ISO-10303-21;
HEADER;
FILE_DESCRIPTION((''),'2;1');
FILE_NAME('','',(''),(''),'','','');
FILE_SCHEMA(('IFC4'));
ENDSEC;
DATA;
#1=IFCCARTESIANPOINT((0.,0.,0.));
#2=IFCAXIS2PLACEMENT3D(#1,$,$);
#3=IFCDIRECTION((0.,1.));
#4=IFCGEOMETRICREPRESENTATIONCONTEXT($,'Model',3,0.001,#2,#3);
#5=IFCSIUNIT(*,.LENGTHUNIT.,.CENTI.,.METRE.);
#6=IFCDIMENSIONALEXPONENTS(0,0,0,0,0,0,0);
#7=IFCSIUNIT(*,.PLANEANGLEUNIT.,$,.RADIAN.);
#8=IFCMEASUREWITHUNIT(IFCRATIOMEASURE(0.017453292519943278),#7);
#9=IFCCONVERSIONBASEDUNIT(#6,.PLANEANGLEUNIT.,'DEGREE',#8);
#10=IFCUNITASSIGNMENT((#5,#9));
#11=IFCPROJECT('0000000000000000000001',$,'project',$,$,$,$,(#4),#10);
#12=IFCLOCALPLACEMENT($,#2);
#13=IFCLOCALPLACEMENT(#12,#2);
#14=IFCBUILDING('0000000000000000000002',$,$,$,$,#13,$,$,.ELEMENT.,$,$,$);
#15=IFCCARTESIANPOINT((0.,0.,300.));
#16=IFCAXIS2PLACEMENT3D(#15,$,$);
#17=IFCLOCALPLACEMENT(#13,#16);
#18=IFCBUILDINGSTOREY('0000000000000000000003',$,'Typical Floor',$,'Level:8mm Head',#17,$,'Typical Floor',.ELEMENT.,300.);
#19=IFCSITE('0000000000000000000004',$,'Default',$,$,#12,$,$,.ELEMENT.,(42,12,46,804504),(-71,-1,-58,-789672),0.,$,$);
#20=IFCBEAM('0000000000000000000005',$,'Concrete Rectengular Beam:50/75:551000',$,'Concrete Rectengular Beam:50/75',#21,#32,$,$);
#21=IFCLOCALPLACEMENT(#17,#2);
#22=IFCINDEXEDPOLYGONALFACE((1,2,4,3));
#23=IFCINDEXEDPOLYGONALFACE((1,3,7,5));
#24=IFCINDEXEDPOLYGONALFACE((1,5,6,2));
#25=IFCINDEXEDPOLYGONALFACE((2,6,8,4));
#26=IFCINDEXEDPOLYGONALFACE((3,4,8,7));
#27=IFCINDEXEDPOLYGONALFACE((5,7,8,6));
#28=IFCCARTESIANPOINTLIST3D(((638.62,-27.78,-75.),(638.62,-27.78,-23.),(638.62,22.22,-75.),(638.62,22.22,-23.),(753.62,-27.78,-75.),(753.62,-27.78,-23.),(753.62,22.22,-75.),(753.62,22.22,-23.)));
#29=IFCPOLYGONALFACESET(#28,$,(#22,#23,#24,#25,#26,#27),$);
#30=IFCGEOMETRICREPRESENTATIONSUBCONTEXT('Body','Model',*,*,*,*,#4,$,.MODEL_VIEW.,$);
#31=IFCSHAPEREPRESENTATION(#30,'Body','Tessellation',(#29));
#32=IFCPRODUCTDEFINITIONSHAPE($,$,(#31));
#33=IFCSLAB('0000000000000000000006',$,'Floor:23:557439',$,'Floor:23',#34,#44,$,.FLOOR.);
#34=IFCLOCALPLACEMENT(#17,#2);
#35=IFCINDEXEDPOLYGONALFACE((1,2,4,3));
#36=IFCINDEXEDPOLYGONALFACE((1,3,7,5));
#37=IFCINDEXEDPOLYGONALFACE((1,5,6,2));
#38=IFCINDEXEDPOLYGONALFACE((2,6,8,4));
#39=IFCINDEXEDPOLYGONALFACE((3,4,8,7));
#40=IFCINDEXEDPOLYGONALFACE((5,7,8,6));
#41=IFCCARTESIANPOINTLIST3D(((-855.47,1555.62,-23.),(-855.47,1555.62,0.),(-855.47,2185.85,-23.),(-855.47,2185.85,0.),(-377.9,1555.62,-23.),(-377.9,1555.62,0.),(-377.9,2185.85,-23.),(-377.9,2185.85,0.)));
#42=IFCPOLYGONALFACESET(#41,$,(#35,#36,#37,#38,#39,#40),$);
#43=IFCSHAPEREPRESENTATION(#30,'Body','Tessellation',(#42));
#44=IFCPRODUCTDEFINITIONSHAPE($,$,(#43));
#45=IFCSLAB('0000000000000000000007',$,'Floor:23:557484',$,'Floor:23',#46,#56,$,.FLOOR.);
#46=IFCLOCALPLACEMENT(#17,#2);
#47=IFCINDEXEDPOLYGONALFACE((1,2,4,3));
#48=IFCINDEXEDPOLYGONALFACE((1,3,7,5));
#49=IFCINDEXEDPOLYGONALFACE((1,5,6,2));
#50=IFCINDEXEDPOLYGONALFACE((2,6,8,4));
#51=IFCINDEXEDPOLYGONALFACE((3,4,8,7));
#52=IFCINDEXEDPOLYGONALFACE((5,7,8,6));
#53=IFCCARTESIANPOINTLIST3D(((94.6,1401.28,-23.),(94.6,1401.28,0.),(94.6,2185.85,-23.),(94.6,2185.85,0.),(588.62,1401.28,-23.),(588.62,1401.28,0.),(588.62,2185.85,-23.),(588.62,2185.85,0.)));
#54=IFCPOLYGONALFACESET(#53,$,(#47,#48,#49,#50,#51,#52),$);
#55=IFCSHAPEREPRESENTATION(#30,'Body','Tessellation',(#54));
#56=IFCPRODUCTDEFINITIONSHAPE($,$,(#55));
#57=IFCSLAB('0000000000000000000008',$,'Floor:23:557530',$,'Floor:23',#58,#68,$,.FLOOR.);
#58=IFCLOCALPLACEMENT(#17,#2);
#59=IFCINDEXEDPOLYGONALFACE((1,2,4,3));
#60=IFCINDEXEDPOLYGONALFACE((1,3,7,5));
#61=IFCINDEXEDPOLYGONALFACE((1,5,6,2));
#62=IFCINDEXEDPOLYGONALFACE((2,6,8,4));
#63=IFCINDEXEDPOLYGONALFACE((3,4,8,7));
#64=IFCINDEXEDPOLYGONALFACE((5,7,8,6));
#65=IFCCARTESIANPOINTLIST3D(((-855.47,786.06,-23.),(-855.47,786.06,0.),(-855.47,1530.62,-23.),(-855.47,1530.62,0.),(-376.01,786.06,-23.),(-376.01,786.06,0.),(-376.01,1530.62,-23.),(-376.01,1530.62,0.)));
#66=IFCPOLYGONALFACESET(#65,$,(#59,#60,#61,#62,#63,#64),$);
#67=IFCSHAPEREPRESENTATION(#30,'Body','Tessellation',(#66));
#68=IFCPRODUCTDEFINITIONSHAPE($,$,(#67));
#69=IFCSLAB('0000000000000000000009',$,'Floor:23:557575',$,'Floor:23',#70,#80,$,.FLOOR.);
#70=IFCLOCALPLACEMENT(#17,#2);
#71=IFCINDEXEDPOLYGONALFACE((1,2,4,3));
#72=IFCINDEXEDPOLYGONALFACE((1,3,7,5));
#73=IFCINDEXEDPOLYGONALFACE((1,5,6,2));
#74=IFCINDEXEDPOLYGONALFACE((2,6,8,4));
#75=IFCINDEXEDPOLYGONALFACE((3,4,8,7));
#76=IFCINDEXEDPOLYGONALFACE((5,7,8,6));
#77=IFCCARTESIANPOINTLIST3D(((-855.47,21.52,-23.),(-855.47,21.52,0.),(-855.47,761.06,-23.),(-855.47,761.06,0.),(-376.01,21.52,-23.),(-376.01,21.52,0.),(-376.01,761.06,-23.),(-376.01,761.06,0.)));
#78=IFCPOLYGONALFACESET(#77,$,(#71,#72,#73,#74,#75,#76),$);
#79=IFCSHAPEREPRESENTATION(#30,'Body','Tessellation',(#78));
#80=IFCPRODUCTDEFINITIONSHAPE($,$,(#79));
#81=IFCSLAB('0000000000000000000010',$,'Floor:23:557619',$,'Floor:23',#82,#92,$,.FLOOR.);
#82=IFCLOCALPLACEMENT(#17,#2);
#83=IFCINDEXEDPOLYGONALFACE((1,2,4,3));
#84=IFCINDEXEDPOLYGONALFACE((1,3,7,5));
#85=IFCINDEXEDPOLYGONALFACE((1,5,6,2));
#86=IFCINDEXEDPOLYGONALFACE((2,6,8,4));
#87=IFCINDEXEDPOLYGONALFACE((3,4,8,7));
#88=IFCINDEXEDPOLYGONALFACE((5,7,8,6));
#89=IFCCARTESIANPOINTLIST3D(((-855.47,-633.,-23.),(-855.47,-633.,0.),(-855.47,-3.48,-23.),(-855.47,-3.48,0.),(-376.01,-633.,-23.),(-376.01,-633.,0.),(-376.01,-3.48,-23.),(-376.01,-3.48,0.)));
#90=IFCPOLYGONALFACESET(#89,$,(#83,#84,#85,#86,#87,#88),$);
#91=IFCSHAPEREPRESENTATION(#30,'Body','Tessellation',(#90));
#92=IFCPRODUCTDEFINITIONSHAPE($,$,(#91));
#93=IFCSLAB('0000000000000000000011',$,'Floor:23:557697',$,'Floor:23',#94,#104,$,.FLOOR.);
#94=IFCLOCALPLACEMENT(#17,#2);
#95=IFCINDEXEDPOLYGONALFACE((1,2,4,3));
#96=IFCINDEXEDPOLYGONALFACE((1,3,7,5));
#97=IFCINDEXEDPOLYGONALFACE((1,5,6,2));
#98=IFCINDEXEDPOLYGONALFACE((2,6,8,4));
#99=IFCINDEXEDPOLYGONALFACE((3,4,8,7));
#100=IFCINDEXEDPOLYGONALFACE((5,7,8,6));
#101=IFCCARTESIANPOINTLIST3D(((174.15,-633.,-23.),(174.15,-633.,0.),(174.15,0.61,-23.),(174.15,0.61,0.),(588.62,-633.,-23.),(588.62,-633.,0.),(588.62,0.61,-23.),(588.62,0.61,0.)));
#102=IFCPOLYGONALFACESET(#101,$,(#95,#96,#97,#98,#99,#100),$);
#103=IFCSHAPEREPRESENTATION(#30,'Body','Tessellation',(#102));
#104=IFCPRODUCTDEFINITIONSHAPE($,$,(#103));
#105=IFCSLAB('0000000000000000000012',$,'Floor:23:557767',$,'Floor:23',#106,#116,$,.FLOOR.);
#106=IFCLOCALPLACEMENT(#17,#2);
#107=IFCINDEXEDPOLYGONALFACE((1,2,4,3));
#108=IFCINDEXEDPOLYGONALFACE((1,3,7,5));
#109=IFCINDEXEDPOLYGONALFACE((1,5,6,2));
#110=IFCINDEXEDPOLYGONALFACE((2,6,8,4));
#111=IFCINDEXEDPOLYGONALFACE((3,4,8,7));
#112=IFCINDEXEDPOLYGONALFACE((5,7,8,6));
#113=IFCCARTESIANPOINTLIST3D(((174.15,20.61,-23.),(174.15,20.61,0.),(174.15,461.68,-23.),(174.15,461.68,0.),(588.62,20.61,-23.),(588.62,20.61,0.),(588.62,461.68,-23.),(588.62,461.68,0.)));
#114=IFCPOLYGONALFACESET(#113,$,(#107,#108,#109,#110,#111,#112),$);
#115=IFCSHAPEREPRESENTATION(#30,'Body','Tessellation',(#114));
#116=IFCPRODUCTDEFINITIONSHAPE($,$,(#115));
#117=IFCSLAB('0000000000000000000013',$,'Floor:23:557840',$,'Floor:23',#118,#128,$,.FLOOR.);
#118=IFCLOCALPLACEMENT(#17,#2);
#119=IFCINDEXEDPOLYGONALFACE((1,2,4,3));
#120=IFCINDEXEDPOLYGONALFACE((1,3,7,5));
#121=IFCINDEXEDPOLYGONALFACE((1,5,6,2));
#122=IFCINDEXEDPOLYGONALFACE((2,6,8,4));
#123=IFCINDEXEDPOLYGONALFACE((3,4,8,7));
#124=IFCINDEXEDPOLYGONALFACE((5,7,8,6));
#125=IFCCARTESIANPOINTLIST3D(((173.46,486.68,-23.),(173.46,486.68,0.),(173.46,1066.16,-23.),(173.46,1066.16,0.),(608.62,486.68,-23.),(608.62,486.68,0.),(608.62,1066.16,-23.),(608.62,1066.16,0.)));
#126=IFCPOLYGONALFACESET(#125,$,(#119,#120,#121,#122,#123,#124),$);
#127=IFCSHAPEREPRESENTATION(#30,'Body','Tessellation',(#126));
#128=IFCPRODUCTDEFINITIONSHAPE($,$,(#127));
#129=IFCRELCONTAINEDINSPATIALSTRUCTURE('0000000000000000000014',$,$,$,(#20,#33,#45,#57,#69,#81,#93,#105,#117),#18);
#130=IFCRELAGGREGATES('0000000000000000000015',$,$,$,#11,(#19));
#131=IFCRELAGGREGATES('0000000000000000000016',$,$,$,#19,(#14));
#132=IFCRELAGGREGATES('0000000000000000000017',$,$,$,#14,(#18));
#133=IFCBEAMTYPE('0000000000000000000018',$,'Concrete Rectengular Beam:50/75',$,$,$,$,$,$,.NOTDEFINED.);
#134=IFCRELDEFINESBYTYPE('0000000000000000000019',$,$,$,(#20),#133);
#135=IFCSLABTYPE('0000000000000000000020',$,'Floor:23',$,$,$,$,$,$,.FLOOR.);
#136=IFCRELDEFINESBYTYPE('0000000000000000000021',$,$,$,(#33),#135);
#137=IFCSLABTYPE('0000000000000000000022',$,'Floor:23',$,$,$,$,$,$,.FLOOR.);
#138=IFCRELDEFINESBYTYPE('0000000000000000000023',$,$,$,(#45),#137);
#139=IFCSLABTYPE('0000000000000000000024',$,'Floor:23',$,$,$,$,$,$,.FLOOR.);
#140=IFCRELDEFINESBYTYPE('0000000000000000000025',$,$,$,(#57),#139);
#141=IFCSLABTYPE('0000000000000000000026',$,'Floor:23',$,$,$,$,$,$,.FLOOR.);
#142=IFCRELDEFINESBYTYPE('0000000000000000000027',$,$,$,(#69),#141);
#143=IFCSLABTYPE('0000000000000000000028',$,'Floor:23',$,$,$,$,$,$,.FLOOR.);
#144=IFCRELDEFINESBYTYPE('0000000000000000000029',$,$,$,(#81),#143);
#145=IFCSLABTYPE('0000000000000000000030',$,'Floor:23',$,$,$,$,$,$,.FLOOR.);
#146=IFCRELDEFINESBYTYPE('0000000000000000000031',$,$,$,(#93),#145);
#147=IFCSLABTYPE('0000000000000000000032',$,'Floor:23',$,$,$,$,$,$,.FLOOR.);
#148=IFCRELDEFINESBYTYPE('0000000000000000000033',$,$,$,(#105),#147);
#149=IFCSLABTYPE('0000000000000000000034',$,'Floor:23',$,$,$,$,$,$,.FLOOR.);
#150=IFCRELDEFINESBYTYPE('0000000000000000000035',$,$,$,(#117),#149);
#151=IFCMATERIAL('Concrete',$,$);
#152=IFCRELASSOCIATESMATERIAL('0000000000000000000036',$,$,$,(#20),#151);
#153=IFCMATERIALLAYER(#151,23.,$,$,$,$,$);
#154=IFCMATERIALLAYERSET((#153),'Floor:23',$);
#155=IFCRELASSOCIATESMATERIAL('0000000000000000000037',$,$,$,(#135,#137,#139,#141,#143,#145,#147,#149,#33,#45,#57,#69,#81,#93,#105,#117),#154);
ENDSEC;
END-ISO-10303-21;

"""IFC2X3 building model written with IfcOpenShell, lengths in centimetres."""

from ifc_helpers import new_model, entity, si_unit, converted_unit, direction, frame, frame_2d, origin, origin_2d_with_axis, place, context, subcontext, project, spatial, rectangle, extrude, material, layer, layer_set, layer_usage, type_object, element, save


model = new_model("IFC2X3")

# Units and contexts
model_context = context("Model", 3, precision=0.001, world=origin(), true_north=direction((0.0, 1.0)))
body_context = subcontext(model_context, "Body", "Model", "MODEL_VIEW")
ifc_project = project(units=[si_unit("LENGTHUNIT", "METRE", prefix="CENTI"), converted_unit("PLANEANGLEUNIT", "DEGREE", entity("IfcRatioMeasure", 0.017453292519943278), si_unit("PLANEANGLEUNIT", "RADIAN"), dimensions=[0, 0, 0, 0, 0, 0, 0])], contexts=[model_context])

# Site, building, storey
site_placement = place(None, origin())
site = spatial("IfcSite", under=ifc_project, at=site_placement, Name="Default", CompositionType="ELEMENT", RefLatitude=(42, 12, 46, 804504), RefLongitude=(-71, -1, -58, -789672), RefElevation=0.0)
building_placement = place(site_placement, origin())
building = spatial("IfcBuilding", under=site, at=building_placement, CompositionType="ELEMENT")
storey_placement = place(building_placement, frame((0.0, 0.0, 300.0)))
storey = spatial("IfcBuildingStorey", under=building, at=storey_placement, Name="Typical Floor", ObjectType="Level:8mm Head", LongName="Typical Floor", CompositionType="ELEMENT", Elevation=300.0)

# Beam
ifc_material = material(Name="Concrete")
beam_type_1 = type_object("IfcBeamType", Name="Concrete Rectengular Beam:50/75", PredefinedType="NOTDEFINED")
beam_1_placement = place(storey_placement, frame((613.62, -2.78, 0.0)))
element("IfcBeam", 1, at=beam_1_placement, inside=storey, type_object=beam_type_1, material=ifc_material, Name="Concrete Rectengular Beam:50/75:551000", ObjectType="Concrete Rectengular Beam:50/75", context=body_context, shape_type="SweptSolid", body=[
    extrude(rectangle(XDim=52.0, YDim=50.0, at=frame_2d((0.0, 0.0), x_axis=(1.0, 0.0))), frame((25.0, 0.0, -49.0), z_axis=(1.0, 0.0, 0.0), x_axis=(0.0, 0.0, -1.0)), (0.0, 0.0, 1.0), 115.0),
])

# Slabs
ifc_layer = layer(ifc_material, 23.0)
ifc_layer_set = layer_set([ifc_layer], Name="Floor:23")
ifc_layer_usage_1 = layer_usage(ifc_layer_set, "AXIS3", "POSITIVE", 0.0)
slab_type_1 = type_object("IfcSlabType", Name="Floor:23", PredefinedType="FLOOR", material=ifc_layer_set)
slab_1_placement = place(storey_placement, origin())
element("IfcSlab", 2, at=slab_1_placement, inside=storey, type_object=slab_type_1, material=ifc_layer_usage_1, Name="Floor:23:557439", ObjectType="Floor:23", PredefinedType="FLOOR", context=body_context, shape_type="SweptSolid", body=[
    extrude(rectangle(XDim=630.23, YDim=477.57, at=frame_2d((0.0, 0.0), x_axis=(1.0, 0.0))), frame((-616.69, 1870.73, 0.0), z_axis=(0.0, 0.0, -1.0), x_axis=(0.0, 1.0, 0.0)), (0.0, 0.0, 1.0), 23.0),
])
ifc_layer_usage_2 = layer_usage(ifc_layer_set, "AXIS3", "POSITIVE", 0.0)
slab_type_2 = type_object("IfcSlabType", Name="Floor:23", PredefinedType="FLOOR", material=ifc_layer_set)
slab_2_placement = place(storey_placement, origin())
element("IfcSlab", 3, at=slab_2_placement, inside=storey, type_object=slab_type_2, material=ifc_layer_usage_2, Name="Floor:23:557484", ObjectType="Floor:23", PredefinedType="FLOOR", context=body_context, shape_type="SweptSolid", body=[
    extrude(rectangle(XDim=784.57, YDim=494.03, at=frame_2d((0.0, 0.0), x_axis=(1.0, 0.0))), frame((341.61, 1793.56, 0.0), z_axis=(0.0, 0.0, -1.0), x_axis=(0.0, 1.0, 0.0)), (0.0, 0.0, 1.0), 23.0),
])
ifc_layer_usage_3 = layer_usage(ifc_layer_set, "AXIS3", "POSITIVE", 0.0)
slab_type_3 = type_object("IfcSlabType", Name="Floor:23", PredefinedType="FLOOR", material=ifc_layer_set)
slab_3_placement = place(storey_placement, origin())
element("IfcSlab", 4, at=slab_3_placement, inside=storey, type_object=slab_type_3, material=ifc_layer_usage_3, Name="Floor:23:557530", ObjectType="Floor:23", PredefinedType="FLOOR", context=body_context, shape_type="SweptSolid", body=[
    extrude(rectangle(XDim=744.56, YDim=479.47, at=frame_2d((0.0, 0.0), x_axis=(1.0, 0.0))), frame((-615.74, 1158.34, 0.0), z_axis=(0.0, 0.0, -1.0), x_axis=(0.0, 1.0, 0.0)), (0.0, 0.0, 1.0), 23.0),
])
ifc_layer_usage_4 = layer_usage(ifc_layer_set, "AXIS3", "POSITIVE", 0.0)
slab_type_4 = type_object("IfcSlabType", Name="Floor:23", PredefinedType="FLOOR", material=ifc_layer_set)
slab_4_placement = place(storey_placement, origin())
element("IfcSlab", 5, at=slab_4_placement, inside=storey, type_object=slab_type_4, material=ifc_layer_usage_4, Name="Floor:23:557575", ObjectType="Floor:23", PredefinedType="FLOOR", context=body_context, shape_type="SweptSolid", body=[
    extrude(rectangle(XDim=739.54, YDim=479.47, at=origin_2d_with_axis()), frame((-615.74, 391.29, 0.0), z_axis=(0.0, 0.0, -1.0), x_axis=(0.0, 1.0, 0.0)), (0.0, 0.0, 1.0), 23.0),
])
ifc_layer_usage_5 = layer_usage(ifc_layer_set, "AXIS3", "POSITIVE", 0.0)
slab_type_5 = type_object("IfcSlabType", Name="Floor:23", PredefinedType="FLOOR", material=ifc_layer_set)
slab_5_placement = place(storey_placement, origin())
element("IfcSlab", 6, at=slab_5_placement, inside=storey, type_object=slab_type_5, material=ifc_layer_usage_5, Name="Floor:23:557619", ObjectType="Floor:23", PredefinedType="FLOOR", context=body_context, shape_type="SweptSolid", body=[
    extrude(rectangle(XDim=629.52, YDim=479.47, at=frame_2d((0.0, 0.0), x_axis=(1.0, 0.0))), frame((-615.74, -318.24, 0.0), z_axis=(0.0, 0.0, -1.0), x_axis=(0.0, 1.0, 0.0)), (0.0, 0.0, 1.0), 23.0),
])
ifc_layer_usage_6 = layer_usage(ifc_layer_set, "AXIS3", "POSITIVE", 0.0)
slab_type_6 = type_object("IfcSlabType", Name="Floor:23", PredefinedType="FLOOR", material=ifc_layer_set)
slab_6_placement = place(storey_placement, origin())
element("IfcSlab", 7, at=slab_6_placement, inside=storey, type_object=slab_type_6, material=ifc_layer_usage_6, Name="Floor:23:557697", ObjectType="Floor:23", PredefinedType="FLOOR", context=body_context, shape_type="SweptSolid", body=[
    extrude(rectangle(XDim=633.61, YDim=414.48, at=origin_2d_with_axis()), frame((381.39, -316.2, 0.0), z_axis=(0.0, 0.0, -1.0), x_axis=(0.0, 1.0, 0.0)), (0.0, 0.0, 1.0), 23.0),
])
ifc_layer_usage_7 = layer_usage(ifc_layer_set, "AXIS3", "POSITIVE", 0.0)
slab_type_7 = type_object("IfcSlabType", Name="Floor:23", PredefinedType="FLOOR", material=ifc_layer_set)
slab_7_placement = place(storey_placement, origin())
element("IfcSlab", 8, at=slab_7_placement, inside=storey, type_object=slab_type_7, material=ifc_layer_usage_7, Name="Floor:23:557767", ObjectType="Floor:23", PredefinedType="FLOOR", context=body_context, shape_type="SweptSolid", body=[
    extrude(rectangle(XDim=441.07, YDim=414.48, at=frame_2d((0.0, 0.0), x_axis=(1.0, 0.0))), frame((381.39, 241.14, 0.0), z_axis=(0.0, 0.0, -1.0), x_axis=(0.0, 1.0, 0.0)), (0.0, 0.0, 1.0), 23.0),
])
ifc_layer_usage_8 = layer_usage(ifc_layer_set, "AXIS3", "POSITIVE", 0.0)
slab_type_8 = type_object("IfcSlabType", Name="Floor:23", PredefinedType="FLOOR", material=ifc_layer_set)
slab_8_placement = place(storey_placement, origin())
element("IfcSlab", 9, at=slab_8_placement, inside=storey, type_object=slab_type_8, material=ifc_layer_usage_8, Name="Floor:23:557840", ObjectType="Floor:23", PredefinedType="FLOOR", context=body_context, shape_type="SweptSolid", body=[
    extrude(rectangle(XDim=579.48, YDim=435.17, at=frame_2d((0.0, 0.0), x_axis=(1.0, 0.0))), frame((391.04, 776.42, 0.0), z_axis=(0.0, 0.0, -1.0), x_axis=(0.0, 1.0, 0.0)), (0.0, 0.0, 1.0), 23.0),
])

save(model, "model.ifc")
